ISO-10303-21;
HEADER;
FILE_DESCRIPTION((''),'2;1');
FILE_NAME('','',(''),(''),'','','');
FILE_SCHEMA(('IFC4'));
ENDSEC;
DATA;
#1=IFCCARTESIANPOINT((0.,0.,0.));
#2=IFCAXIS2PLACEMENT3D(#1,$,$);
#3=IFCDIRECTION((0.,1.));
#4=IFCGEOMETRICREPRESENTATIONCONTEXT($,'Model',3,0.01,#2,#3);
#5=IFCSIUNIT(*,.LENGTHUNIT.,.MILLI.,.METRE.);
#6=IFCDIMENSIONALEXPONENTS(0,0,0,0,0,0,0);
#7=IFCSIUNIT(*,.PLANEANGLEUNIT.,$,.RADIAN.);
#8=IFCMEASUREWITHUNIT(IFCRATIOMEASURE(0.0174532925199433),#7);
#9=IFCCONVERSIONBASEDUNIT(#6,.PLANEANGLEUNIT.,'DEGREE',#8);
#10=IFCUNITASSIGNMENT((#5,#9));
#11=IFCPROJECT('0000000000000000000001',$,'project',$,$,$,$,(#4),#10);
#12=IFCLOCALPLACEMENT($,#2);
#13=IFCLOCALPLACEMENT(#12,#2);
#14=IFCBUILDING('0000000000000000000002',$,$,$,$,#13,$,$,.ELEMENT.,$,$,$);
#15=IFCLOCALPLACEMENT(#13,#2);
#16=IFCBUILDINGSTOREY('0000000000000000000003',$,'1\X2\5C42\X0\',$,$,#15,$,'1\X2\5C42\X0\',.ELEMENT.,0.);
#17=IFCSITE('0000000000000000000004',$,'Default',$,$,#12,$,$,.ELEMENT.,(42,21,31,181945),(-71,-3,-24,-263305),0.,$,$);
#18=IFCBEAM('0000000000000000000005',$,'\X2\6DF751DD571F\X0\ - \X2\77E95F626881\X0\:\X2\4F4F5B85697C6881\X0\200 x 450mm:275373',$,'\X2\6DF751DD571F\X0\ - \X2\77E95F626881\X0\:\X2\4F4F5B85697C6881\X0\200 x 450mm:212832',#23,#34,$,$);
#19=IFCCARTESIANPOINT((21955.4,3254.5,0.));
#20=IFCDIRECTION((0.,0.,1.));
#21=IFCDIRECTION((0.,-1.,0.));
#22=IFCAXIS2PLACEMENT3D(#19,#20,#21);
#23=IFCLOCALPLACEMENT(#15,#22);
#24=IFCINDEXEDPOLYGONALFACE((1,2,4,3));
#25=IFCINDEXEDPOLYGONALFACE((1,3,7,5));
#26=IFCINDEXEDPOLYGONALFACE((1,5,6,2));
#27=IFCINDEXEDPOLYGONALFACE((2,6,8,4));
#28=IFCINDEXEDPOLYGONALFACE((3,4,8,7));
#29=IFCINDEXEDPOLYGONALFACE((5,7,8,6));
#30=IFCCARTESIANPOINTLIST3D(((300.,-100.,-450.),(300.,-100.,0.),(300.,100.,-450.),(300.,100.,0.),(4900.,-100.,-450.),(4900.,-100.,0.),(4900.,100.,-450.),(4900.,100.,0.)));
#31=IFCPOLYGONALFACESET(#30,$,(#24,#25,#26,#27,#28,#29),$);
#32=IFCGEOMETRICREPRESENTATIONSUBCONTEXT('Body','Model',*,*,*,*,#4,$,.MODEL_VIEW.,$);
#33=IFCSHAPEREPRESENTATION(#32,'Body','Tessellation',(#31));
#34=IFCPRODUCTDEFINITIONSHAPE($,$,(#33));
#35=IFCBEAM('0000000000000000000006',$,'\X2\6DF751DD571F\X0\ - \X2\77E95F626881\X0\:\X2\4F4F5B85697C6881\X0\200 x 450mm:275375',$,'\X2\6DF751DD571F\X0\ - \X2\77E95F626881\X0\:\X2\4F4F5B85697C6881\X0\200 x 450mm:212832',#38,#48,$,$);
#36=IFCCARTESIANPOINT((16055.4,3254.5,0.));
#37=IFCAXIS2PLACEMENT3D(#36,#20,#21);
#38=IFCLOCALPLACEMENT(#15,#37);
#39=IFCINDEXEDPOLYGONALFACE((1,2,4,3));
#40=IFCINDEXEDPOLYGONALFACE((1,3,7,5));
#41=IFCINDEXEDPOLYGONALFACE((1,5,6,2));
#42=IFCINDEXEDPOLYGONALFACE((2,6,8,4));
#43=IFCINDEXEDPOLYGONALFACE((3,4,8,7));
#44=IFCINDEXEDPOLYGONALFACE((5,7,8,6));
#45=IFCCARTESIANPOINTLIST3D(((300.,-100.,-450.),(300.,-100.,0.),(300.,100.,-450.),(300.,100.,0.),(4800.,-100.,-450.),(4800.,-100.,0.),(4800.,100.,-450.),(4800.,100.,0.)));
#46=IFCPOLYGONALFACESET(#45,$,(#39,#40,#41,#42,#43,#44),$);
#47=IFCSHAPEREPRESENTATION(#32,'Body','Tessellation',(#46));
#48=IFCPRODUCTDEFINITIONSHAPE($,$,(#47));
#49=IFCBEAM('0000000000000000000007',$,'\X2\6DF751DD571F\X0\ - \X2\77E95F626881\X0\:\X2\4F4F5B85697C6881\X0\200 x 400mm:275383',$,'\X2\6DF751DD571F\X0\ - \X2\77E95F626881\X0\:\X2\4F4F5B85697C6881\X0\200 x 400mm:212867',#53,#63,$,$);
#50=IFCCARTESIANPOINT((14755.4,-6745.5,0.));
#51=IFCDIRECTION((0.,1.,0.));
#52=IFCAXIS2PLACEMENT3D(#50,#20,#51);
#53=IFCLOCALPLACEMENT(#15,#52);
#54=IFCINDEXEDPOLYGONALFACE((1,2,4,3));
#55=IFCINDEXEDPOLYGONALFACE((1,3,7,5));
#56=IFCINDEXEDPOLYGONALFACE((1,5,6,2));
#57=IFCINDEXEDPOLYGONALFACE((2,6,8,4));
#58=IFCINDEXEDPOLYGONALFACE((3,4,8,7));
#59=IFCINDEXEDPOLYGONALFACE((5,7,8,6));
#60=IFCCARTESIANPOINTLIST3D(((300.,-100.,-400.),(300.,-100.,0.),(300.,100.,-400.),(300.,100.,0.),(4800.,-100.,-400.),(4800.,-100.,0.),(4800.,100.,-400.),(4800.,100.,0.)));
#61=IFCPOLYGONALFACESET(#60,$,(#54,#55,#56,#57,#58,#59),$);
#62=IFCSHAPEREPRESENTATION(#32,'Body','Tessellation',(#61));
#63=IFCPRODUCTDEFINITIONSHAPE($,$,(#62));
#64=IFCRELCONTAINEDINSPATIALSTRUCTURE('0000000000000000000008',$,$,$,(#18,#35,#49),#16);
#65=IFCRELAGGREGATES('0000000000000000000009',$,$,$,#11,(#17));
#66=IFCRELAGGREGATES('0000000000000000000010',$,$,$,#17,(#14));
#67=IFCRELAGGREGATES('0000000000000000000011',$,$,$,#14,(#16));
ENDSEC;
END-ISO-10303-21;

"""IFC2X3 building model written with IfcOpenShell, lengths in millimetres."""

from ifc_helpers import new_model, entity, si_unit, converted_unit, direction, frame, frame_2d, origin, place, context, subcontext, project, spatial, rectangle, extrude, element, save


model = new_model("IFC2X3")

# Units and contexts
model_context = context("Model", 3, precision=0.01, world=origin(), true_north=direction((0.0, 1.0)))
body_context = subcontext(model_context, "Body", "Model", "MODEL_VIEW")
ifc_project = project(units=[si_unit("LENGTHUNIT", "METRE", prefix="MILLI"), converted_unit("PLANEANGLEUNIT", "DEGREE", entity("IfcRatioMeasure", 0.0174532925199433), si_unit("PLANEANGLEUNIT", "RADIAN"), dimensions=[0, 0, 0, 0, 0, 0, 0])], contexts=[model_context])

# Site, building, storey
site_placement = place(None, origin())
site = spatial("IfcSite", under=ifc_project, at=site_placement, Name="Default", CompositionType="ELEMENT", RefLatitude=(42, 21, 31, 181945), RefLongitude=(-71, -3, -24, -263305), RefElevation=0.0)
building_placement = place(site_placement, origin())
building = spatial("IfcBuilding", under=site, at=building_placement, CompositionType="ELEMENT")
storey_placement = place(building_placement, origin())
storey = spatial("IfcBuildingStorey", under=building, at=storey_placement, Name="1层", LongName="1层", CompositionType="ELEMENT", Elevation=0.0)

# Beams
beam_1_placement = place(storey_placement, frame((21955.4, 3254.5, 0.0), z_axis=(0.0, 0.0, 1.0), x_axis=(0.0, -1.0, 0.0)))
element("IfcBeam", 1, at=beam_1_placement, inside=storey, Name="混凝土 - 矩形梁:住宅楼梁200 x 450mm:275373", ObjectType="混凝土 - 矩形梁:住宅楼梁200 x 450mm:212832", context=body_context, shape_type="SweptSolid", body=[
    extrude(rectangle(XDim=450.0, YDim=200.0, at=frame_2d((0.0, 0.0), x_axis=(1.0, 0.0))), frame((300.0, 0.0, -225.0), z_axis=(1.0, 0.0, 0.0), x_axis=(0.0, 0.0, -1.0)), (0.0, 0.0, 1.0), 4600.0),
])
beam_2_placement = place(storey_placement, frame((16055.4, 3254.5, 0.0), z_axis=(0.0, 0.0, 1.0), x_axis=(0.0, -1.0, 0.0)))
element("IfcBeam", 2, at=beam_2_placement, inside=storey, Name="混凝土 - 矩形梁:住宅楼梁200 x 450mm:275375", ObjectType="混凝土 - 矩形梁:住宅楼梁200 x 450mm:212832", context=body_context, shape_type="SweptSolid", body=[
    extrude(rectangle(XDim=450.0, YDim=200.0, at=frame_2d((0.0, 0.0), x_axis=(1.0, 0.0))), frame((300.0, 0.0, -225.0), z_axis=(1.0, 0.0, 0.0), x_axis=(0.0, 0.0, -1.0)), (0.0, 0.0, 1.0), 4500.0),
])
beam_3_placement = place(storey_placement, frame((14755.4, -6745.5, 0.0), z_axis=(0.0, 0.0, 1.0), x_axis=(0.0, 1.0, 0.0)))
element("IfcBeam", 3, at=beam_3_placement, inside=storey, Name="混凝土 - 矩形梁:住宅楼梁200 x 400mm:275383", ObjectType="混凝土 - 矩形梁:住宅楼梁200 x 400mm:212867", context=body_context, shape_type="SweptSolid", body=[
    extrude(rectangle(XDim=400.0, YDim=200.0, at=frame_2d((0.0, 0.0), x_axis=(1.0, 0.0))), frame((300.0, 0.0, -200.0), z_axis=(1.0, 0.0, 0.0), x_axis=(0.0, 0.0, -1.0)), (0.0, 0.0, 1.0), 4500.0),
])

save(model, "model.ifc")
